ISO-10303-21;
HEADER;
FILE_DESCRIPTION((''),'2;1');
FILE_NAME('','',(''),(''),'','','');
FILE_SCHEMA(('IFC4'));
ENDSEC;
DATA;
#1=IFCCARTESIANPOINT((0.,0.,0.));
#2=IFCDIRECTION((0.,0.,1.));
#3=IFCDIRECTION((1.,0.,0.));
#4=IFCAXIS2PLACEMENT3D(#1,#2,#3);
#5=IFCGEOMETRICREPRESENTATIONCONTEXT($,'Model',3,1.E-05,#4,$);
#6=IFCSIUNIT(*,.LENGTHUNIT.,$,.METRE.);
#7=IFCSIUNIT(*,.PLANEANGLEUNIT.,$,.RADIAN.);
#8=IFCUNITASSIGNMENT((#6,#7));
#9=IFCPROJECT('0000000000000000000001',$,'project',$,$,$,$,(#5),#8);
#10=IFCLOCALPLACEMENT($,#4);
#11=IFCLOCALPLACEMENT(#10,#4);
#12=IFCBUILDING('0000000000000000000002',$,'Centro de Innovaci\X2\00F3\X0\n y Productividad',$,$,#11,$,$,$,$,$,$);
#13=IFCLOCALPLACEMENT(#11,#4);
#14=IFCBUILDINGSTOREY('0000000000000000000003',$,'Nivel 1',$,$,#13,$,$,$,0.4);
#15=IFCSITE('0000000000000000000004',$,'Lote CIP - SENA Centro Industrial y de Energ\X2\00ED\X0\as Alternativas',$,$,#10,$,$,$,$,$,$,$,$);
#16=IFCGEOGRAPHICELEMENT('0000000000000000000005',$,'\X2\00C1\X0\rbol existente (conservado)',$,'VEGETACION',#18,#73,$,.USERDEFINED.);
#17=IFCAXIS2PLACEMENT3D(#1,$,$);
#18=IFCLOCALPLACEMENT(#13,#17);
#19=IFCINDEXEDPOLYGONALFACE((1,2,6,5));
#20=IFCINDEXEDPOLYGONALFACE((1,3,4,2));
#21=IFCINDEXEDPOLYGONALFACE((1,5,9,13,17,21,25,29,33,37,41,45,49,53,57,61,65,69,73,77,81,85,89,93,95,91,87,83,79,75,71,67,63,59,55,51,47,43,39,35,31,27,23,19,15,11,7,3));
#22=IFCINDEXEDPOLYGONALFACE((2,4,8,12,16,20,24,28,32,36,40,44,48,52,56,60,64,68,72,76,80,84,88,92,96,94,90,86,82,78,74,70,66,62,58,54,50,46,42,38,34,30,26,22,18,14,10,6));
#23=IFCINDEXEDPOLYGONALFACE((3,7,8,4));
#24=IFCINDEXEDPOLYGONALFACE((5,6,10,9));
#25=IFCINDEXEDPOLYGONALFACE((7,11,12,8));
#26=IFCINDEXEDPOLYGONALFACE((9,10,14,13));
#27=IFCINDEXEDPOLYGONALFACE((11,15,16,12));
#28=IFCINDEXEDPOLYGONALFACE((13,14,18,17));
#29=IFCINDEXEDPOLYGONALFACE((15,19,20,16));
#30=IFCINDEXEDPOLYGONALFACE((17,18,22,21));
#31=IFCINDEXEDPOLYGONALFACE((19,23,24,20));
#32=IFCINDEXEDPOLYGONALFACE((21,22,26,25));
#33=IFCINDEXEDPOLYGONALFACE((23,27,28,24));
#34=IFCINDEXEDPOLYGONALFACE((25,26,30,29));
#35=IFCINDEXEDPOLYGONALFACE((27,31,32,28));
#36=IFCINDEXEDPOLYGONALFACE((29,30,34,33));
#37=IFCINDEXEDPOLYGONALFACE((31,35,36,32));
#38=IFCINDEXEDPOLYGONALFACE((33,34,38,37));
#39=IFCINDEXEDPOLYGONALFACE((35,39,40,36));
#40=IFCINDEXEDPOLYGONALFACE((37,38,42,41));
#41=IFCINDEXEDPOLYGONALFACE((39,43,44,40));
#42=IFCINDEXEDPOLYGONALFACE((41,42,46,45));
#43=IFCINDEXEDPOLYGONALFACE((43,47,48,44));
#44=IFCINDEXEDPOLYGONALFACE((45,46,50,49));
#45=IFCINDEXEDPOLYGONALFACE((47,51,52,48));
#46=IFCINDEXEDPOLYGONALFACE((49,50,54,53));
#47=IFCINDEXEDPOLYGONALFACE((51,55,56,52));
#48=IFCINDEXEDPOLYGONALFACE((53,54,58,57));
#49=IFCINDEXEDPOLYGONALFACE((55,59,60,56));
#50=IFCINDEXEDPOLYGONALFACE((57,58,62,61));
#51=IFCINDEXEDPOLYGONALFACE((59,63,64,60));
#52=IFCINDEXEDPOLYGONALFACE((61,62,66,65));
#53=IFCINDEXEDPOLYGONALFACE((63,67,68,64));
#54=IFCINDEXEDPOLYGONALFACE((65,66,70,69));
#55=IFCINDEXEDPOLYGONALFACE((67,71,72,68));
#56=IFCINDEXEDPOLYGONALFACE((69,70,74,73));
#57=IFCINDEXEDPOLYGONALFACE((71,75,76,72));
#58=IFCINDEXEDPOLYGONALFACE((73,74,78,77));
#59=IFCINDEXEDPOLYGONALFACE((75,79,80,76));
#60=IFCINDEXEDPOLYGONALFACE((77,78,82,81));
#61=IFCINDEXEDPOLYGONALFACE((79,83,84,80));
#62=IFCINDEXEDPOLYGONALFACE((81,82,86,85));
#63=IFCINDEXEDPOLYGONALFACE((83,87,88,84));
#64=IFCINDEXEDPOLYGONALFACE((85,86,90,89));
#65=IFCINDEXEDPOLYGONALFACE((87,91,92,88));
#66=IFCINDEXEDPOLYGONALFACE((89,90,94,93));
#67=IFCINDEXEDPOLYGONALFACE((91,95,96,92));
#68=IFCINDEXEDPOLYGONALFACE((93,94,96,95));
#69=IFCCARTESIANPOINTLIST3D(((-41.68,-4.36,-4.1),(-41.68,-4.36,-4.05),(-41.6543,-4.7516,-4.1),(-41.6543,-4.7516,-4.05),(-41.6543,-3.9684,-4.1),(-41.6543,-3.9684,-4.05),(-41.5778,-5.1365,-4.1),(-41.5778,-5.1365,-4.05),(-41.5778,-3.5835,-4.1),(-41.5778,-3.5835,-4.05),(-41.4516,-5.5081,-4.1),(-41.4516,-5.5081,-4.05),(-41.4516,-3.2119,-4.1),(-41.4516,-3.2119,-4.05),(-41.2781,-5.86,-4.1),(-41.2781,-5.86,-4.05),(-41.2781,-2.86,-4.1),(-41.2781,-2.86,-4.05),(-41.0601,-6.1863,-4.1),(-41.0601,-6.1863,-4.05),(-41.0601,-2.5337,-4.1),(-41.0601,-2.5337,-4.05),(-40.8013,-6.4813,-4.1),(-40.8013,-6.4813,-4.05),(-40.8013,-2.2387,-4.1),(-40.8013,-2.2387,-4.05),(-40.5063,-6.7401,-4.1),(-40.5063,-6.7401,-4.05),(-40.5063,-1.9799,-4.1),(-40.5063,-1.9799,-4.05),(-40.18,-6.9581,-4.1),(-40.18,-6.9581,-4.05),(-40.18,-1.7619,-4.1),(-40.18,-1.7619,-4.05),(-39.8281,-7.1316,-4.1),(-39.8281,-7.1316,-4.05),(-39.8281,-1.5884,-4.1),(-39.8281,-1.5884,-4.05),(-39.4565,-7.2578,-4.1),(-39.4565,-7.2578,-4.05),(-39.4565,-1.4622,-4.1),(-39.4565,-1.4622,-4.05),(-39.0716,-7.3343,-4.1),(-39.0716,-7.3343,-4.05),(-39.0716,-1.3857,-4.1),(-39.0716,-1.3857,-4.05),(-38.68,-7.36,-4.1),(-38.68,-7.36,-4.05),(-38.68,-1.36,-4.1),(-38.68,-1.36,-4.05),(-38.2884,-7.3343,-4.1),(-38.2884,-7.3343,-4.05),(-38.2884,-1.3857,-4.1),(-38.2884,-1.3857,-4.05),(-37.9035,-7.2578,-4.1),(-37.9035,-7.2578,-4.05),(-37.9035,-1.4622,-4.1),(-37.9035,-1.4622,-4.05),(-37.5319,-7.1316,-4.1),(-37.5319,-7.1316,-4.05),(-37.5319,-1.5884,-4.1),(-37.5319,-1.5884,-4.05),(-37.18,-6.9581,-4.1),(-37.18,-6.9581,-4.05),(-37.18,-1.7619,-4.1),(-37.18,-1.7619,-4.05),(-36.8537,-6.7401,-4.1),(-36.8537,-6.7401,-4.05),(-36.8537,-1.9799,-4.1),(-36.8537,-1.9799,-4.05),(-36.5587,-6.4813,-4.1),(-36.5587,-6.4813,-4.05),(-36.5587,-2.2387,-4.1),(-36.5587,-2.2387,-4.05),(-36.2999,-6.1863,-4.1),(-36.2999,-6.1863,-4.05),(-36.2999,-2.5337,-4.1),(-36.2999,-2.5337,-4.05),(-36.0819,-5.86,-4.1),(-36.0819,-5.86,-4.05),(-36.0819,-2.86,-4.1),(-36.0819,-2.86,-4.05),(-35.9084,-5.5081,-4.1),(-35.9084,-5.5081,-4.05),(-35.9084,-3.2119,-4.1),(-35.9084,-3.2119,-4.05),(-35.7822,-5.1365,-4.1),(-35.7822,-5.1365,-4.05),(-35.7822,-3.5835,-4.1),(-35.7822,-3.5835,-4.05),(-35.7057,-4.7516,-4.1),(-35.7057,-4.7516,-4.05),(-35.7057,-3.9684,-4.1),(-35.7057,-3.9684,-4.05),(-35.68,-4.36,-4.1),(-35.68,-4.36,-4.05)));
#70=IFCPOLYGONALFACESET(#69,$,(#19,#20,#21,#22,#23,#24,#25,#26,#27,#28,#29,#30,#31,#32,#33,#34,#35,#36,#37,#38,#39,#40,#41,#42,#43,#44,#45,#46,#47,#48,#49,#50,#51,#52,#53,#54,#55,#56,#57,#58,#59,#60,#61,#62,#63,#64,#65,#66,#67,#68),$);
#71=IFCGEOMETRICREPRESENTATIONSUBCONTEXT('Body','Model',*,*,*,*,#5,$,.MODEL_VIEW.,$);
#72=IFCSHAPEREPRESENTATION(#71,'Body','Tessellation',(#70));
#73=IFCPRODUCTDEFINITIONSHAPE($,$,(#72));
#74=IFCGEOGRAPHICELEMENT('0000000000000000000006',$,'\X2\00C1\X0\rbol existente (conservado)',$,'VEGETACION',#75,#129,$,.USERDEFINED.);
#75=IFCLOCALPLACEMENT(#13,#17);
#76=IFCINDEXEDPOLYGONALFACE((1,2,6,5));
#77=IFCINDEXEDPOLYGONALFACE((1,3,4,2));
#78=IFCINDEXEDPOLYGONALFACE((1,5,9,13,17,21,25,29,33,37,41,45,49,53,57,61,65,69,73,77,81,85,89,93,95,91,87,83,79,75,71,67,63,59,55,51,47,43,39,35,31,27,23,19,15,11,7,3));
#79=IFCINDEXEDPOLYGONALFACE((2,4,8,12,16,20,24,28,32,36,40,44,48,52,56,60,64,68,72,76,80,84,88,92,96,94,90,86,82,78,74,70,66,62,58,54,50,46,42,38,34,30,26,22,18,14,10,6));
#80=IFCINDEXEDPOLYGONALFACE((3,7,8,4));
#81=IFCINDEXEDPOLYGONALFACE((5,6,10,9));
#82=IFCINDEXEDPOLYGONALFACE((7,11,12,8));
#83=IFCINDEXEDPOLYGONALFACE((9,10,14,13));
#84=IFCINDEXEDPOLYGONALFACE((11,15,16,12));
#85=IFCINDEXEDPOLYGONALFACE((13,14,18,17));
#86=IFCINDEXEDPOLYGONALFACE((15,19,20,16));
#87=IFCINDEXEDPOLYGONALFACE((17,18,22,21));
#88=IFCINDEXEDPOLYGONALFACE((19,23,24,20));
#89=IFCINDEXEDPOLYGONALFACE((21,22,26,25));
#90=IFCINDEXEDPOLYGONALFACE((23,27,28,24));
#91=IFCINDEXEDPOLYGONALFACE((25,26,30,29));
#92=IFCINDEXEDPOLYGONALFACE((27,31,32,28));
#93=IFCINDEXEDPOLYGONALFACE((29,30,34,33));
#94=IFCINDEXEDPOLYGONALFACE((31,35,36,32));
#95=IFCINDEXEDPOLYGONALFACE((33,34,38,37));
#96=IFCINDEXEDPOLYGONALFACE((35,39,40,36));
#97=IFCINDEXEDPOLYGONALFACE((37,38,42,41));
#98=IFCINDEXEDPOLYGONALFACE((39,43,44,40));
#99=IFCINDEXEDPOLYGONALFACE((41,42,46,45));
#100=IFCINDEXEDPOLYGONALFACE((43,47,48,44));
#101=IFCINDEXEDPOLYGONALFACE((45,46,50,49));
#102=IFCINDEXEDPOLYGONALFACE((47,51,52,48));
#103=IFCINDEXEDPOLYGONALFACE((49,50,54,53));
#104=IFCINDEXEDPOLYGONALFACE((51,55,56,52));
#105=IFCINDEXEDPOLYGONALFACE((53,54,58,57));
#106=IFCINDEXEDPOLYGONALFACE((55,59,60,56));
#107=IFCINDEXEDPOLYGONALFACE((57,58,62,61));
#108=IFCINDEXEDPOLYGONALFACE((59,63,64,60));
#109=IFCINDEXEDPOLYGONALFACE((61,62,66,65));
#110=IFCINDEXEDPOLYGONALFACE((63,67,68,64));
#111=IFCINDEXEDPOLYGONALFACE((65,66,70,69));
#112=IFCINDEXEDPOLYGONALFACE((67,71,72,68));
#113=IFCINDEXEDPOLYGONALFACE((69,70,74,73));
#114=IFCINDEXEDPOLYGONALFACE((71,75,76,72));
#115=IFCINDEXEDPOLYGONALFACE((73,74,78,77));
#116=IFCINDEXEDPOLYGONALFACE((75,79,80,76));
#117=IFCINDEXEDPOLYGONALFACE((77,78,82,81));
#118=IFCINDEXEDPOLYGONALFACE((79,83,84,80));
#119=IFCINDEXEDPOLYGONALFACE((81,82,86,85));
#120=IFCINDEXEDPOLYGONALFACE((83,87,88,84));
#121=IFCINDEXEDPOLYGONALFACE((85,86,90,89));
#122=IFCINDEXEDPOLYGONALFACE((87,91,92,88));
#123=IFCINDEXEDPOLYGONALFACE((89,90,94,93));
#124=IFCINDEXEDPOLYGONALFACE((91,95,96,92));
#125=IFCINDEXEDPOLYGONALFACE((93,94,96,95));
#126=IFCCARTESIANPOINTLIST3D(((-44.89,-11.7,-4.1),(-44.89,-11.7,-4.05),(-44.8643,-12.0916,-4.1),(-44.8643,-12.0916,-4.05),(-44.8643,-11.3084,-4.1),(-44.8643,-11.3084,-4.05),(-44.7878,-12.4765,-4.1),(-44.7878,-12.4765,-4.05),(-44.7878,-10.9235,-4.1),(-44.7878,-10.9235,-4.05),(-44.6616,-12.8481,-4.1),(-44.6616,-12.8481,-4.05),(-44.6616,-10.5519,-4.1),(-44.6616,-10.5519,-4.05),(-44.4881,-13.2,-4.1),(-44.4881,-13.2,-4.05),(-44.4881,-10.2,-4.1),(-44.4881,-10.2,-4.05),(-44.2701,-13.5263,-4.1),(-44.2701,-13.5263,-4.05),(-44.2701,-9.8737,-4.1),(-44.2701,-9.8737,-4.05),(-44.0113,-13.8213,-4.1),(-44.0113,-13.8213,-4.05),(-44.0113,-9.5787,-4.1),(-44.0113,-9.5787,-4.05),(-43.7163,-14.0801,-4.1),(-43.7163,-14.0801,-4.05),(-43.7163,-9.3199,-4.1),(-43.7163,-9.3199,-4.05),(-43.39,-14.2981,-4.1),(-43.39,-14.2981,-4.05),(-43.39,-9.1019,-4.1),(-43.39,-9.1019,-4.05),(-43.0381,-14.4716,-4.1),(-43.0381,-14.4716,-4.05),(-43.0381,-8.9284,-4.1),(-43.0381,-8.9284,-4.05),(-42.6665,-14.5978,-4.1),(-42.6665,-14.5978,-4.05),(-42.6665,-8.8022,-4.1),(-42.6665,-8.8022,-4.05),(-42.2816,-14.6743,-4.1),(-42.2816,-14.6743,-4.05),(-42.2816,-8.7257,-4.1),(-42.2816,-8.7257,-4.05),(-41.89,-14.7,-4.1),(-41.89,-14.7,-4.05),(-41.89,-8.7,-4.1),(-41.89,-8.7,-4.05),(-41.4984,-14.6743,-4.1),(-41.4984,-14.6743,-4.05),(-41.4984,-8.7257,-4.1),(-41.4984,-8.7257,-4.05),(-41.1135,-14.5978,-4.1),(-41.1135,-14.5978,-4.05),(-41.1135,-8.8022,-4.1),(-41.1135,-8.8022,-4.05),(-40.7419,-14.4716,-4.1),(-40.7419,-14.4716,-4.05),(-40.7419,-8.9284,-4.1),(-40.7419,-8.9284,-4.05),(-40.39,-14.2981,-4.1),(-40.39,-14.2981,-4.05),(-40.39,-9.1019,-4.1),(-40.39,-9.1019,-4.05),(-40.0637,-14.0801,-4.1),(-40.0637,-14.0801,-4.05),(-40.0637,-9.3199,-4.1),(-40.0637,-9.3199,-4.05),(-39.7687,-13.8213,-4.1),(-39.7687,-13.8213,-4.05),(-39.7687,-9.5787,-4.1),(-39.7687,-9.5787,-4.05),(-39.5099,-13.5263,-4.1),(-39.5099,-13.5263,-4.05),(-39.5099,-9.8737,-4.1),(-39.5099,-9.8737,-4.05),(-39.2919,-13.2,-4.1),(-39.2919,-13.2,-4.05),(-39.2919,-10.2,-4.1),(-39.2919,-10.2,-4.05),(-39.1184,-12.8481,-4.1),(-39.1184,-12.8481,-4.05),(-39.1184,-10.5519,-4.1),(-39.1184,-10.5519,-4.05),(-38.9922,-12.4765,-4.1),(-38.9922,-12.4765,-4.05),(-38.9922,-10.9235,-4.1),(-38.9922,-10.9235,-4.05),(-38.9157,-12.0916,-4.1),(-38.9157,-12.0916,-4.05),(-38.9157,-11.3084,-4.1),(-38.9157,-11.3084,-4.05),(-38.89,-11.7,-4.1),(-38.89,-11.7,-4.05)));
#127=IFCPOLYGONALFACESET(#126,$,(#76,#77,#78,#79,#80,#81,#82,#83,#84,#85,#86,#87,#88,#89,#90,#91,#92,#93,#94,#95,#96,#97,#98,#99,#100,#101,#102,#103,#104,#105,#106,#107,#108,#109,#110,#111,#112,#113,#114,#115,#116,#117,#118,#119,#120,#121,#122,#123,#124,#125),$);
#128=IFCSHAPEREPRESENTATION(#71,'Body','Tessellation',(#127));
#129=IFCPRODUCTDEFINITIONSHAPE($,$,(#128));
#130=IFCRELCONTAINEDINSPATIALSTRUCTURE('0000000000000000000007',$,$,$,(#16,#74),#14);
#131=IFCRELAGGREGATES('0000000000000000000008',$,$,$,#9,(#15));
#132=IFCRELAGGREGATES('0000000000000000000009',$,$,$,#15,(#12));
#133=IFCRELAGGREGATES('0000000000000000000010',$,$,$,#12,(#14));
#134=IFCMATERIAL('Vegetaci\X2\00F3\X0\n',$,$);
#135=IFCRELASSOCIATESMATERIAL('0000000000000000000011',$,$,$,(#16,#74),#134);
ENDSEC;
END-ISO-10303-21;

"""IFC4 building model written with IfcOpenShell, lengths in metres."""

from ifc_helpers import new_model, si_unit, frame, origin_with_axes, place, context, subcontext, project, spatial, polyline, outline, extrude, material, element, save


model = new_model("IFC4")

# Units and contexts
model_context = context("Model", 3, precision=1e-05, world=origin_with_axes())
body_context = subcontext(model_context, "Body", "Model", "MODEL_VIEW")
ifc_project = project(units=[si_unit("LENGTHUNIT", "METRE"), si_unit("PLANEANGLEUNIT", "RADIAN")], contexts=[model_context])

# Site, building, storey
site_placement = place(None, origin_with_axes())
site = spatial("IfcSite", under=ifc_project, at=site_placement, Name="Lote CIP - SENA Centro Industrial y de Energías Alternativas")
building_placement = place(site_placement, origin_with_axes())
building = spatial("IfcBuilding", under=site, at=building_placement, Name="Centro de Innovación y Productividad")
storey_placement = place(building_placement, origin_with_axes())
storey = spatial("IfcBuildingStorey", under=building, at=storey_placement, Name="Nivel 1", Elevation=0.4)

# Geographic elements
ifc_material_1 = material(Name="Vegetación")
geographic_element_1_placement = place(storey_placement, origin_with_axes())
element("IfcGeographicElement", 1, at=geographic_element_1_placement, inside=storey, material=ifc_material_1, Name="Árbol existente (conservado)", ObjectType="VEGETACION", PredefinedType="USERDEFINED", context=body_context, shape_type="SweptSolid", body=[
    extrude(outline(polyline([(-35.68, -4.36), (-35.7057, -4.7516), (-35.7822, -5.1365), (-35.9084, -5.5081), (-36.0819, -5.86), (-36.2999, -6.1863), (-36.5587, -6.4813), (-36.8537, -6.7401), (-37.18, -6.9581), (-37.5319, -7.1316), (-37.9035, -7.2578), (-38.2884, -7.3343), (-38.68, -7.36), (-39.0716, -7.3343), (-39.4565, -7.2578), (-39.8281, -7.1316), (-40.18, -6.9581), (-40.5063, -6.7401), (-40.8013, -6.4813), (-41.0601, -6.1863), (-41.2781, -5.86), (-41.4516, -5.5081), (-41.5778, -5.1365), (-41.6543, -4.7516), (-41.68, -4.36), (-41.6543, -3.9684), (-41.5778, -3.5835), (-41.4516, -3.2119), (-41.2781, -2.86), (-41.0601, -2.5337), (-40.8013, -2.2387), (-40.5063, -1.9799), (-40.18, -1.7619), (-39.8281, -1.5884), (-39.4565, -1.4622), (-39.0716, -1.3857), (-38.68, -1.36), (-38.2884, -1.3857), (-37.9035, -1.4622), (-37.5319, -1.5884), (-37.18, -1.7619), (-36.8537, -1.9799), (-36.5587, -2.2387), (-36.2999, -2.5337), (-36.0819, -2.86), (-35.9084, -3.2119), (-35.7822, -3.5835), (-35.7057, -3.9684), (-35.68, -4.36)])), frame((0.0, 0.0, -4.1)), (0.0, 0.0, 1.0), 0.05),
])
geographic_element_2_placement = place(storey_placement, origin_with_axes())
element("IfcGeographicElement", 2, at=geographic_element_2_placement, inside=storey, material=ifc_material_1, Name="Árbol existente (conservado)", ObjectType="VEGETACION", PredefinedType="USERDEFINED", context=body_context, shape_type="SweptSolid", body=[
    extrude(outline(polyline([(-38.89, -11.7), (-38.9157, -12.0916), (-38.9922, -12.4765), (-39.1184, -12.8481), (-39.2919, -13.2), (-39.5099, -13.5263), (-39.7687, -13.8213), (-40.0637, -14.0801), (-40.39, -14.2981), (-40.7419, -14.4716), (-41.1135, -14.5978), (-41.4984, -14.6743), (-41.89, -14.7), (-42.2816, -14.6743), (-42.6665, -14.5978), (-43.0381, -14.4716), (-43.39, -14.2981), (-43.7163, -14.0801), (-44.0113, -13.8213), (-44.2701, -13.5263), (-44.4881, -13.2), (-44.6616, -12.8481), (-44.7878, -12.4765), (-44.8643, -12.0916), (-44.89, -11.7), (-44.8643, -11.3084), (-44.7878, -10.9235), (-44.6616, -10.5519), (-44.4881, -10.2), (-44.2701, -9.8737), (-44.0113, -9.5787), (-43.7163, -9.3199), (-43.39, -9.1019), (-43.0381, -8.9284), (-42.6665, -8.8022), (-42.2816, -8.7257), (-41.89, -8.7), (-41.4984, -8.7257), (-41.1135, -8.8022), (-40.7419, -8.9284), (-40.39, -9.1019), (-40.0637, -9.3199), (-39.7687, -9.5787), (-39.5099, -9.8737), (-39.2919, -10.2), (-39.1184, -10.5519), (-38.9922, -10.9235), (-38.9157, -11.3084), (-38.89, -11.7)])), frame((0.0, 0.0, -4.1)), (0.0, 0.0, 1.0), 0.05),
])

save(model, "model.ifc")
